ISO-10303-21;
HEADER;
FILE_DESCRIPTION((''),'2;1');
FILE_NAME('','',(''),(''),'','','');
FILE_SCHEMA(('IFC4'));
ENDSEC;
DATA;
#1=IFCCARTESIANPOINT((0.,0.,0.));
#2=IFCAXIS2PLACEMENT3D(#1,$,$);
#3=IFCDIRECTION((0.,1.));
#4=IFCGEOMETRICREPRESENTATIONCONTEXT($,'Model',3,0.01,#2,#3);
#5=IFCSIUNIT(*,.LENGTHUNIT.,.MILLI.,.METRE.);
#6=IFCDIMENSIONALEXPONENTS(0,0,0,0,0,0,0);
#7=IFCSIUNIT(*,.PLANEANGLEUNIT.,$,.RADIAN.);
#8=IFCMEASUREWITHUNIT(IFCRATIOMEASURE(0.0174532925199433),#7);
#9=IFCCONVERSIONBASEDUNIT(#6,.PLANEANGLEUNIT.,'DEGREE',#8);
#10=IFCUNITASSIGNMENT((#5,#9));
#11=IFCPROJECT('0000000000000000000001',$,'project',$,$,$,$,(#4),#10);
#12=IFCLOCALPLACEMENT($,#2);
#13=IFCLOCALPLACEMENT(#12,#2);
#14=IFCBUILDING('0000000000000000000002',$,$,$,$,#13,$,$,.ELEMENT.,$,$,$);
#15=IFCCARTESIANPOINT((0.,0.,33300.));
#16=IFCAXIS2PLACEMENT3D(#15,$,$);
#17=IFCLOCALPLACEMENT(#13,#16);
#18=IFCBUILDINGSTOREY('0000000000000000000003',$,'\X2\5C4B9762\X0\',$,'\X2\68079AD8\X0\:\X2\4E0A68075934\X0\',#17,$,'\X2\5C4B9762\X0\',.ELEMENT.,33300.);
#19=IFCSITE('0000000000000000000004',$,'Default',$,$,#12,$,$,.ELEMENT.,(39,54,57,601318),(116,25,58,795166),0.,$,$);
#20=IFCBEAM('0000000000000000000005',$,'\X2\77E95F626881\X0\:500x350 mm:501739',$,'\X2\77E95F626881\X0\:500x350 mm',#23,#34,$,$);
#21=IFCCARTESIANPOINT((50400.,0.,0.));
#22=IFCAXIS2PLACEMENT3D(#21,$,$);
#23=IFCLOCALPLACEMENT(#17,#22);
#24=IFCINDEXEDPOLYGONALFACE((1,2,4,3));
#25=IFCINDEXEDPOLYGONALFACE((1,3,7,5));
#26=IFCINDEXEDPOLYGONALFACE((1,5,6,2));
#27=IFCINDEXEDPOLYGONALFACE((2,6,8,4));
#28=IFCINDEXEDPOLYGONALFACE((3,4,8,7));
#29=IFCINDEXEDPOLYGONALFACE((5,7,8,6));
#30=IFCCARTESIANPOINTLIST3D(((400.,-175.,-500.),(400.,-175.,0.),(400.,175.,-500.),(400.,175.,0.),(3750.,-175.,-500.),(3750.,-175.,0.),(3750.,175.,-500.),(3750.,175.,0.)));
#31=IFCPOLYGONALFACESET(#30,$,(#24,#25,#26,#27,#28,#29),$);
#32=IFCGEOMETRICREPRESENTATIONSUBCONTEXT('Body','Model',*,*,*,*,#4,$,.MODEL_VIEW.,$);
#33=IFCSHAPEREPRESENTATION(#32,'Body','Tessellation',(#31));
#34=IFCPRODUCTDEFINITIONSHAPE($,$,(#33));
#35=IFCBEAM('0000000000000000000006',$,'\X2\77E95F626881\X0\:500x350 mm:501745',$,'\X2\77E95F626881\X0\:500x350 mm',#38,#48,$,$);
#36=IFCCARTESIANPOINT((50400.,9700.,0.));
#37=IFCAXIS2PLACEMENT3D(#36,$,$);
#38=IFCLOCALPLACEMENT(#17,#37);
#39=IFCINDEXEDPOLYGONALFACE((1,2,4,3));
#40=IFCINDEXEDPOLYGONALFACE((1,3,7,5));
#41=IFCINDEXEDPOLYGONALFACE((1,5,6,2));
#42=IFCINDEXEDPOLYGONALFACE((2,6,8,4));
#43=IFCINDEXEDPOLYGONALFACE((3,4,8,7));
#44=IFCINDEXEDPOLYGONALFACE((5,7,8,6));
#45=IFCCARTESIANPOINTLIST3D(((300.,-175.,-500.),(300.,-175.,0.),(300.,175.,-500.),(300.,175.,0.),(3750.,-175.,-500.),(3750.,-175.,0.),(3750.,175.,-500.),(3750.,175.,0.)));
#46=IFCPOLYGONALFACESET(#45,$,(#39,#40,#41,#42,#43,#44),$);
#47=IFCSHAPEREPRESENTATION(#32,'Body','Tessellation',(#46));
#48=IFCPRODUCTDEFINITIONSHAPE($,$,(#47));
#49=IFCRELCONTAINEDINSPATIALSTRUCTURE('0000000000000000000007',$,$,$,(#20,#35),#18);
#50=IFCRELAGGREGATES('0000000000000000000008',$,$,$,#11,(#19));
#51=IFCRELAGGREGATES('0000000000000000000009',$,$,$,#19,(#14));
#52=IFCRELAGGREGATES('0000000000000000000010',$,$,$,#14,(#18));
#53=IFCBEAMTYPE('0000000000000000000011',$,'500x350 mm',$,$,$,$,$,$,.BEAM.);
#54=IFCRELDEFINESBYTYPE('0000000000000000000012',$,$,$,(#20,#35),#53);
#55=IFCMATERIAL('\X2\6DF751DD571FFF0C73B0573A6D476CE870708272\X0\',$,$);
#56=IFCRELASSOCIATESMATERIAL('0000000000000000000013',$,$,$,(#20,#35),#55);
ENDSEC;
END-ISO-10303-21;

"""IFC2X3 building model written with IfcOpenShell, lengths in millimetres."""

from ifc_helpers import new_model, entity, si_unit, converted_unit, direction, frame, frame_2d, origin, origin_2d_with_axis, place, context, subcontext, project, spatial, rectangle, extrude, material, type_object, element, save


model = new_model("IFC2X3")

# Units and contexts
model_context = context("Model", 3, precision=0.01, world=origin(), true_north=direction((0.0, 1.0)))
body_context = subcontext(model_context, "Body", "Model", "MODEL_VIEW")
ifc_project = project(units=[si_unit("LENGTHUNIT", "METRE", prefix="MILLI"), converted_unit("PLANEANGLEUNIT", "DEGREE", entity("IfcRatioMeasure", 0.0174532925199433), si_unit("PLANEANGLEUNIT", "RADIAN"), dimensions=[0, 0, 0, 0, 0, 0, 0])], contexts=[model_context])

# Site, building, storey
site_placement = place(None, origin())
site = spatial("IfcSite", under=ifc_project, at=site_placement, Name="Default", CompositionType="ELEMENT", RefLatitude=(39, 54, 57, 601318), RefLongitude=(116, 25, 58, 795166), RefElevation=0.0)
building_placement = place(site_placement, origin())
building = spatial("IfcBuilding", under=site, at=building_placement, CompositionType="ELEMENT")
storey_placement = place(building_placement, frame((0.0, 0.0, 33300.0)))
storey = spatial("IfcBuildingStorey", under=building, at=storey_placement, Name="屋面", ObjectType="标高:上标头", LongName="屋面", CompositionType="ELEMENT", Elevation=33300.0)

# Beams
ifc_material_1 = material(Name="混凝土，现场浇注灰色")
beam_type_1 = type_object("IfcBeamType", Name="500x350 mm", PredefinedType="BEAM")
beam_1_placement = place(storey_placement, frame((50400.0, 0.0, 0.0)))
element("IfcBeam", 1, at=beam_1_placement, inside=storey, type_object=beam_type_1, material=ifc_material_1, Name="矩形梁:500x350 mm:501739", ObjectType="矩形梁:500x350 mm", context=body_context, shape_type="SweptSolid", body=[
    extrude(rectangle(XDim=500.0, YDim=350.0, at=origin_2d_with_axis()), frame((400.0, 0.0, -250.0), z_axis=(1.0, 0.0, 0.0), x_axis=(0.0, 0.0, -1.0)), (0.0, 0.0, 1.0), 3350.0),
])
beam_2_placement = place(storey_placement, frame((50400.0, 9700.0, 0.0)))
element("IfcBeam", 2, at=beam_2_placement, inside=storey, type_object=beam_type_1, material=ifc_material_1, Name="矩形梁:500x350 mm:501745", ObjectType="矩形梁:500x350 mm", context=body_context, shape_type="SweptSolid", body=[
    extrude(rectangle(XDim=500.0, YDim=350.0, at=frame_2d((0.0, 0.0), x_axis=(1.0, 0.0))), frame((300.0, 0.0, -250.0), z_axis=(1.0, 0.0, 0.0), x_axis=(0.0, 0.0, -1.0)), (0.0, 0.0, 1.0), 3450.0),
])

save(model, "model.ifc")
